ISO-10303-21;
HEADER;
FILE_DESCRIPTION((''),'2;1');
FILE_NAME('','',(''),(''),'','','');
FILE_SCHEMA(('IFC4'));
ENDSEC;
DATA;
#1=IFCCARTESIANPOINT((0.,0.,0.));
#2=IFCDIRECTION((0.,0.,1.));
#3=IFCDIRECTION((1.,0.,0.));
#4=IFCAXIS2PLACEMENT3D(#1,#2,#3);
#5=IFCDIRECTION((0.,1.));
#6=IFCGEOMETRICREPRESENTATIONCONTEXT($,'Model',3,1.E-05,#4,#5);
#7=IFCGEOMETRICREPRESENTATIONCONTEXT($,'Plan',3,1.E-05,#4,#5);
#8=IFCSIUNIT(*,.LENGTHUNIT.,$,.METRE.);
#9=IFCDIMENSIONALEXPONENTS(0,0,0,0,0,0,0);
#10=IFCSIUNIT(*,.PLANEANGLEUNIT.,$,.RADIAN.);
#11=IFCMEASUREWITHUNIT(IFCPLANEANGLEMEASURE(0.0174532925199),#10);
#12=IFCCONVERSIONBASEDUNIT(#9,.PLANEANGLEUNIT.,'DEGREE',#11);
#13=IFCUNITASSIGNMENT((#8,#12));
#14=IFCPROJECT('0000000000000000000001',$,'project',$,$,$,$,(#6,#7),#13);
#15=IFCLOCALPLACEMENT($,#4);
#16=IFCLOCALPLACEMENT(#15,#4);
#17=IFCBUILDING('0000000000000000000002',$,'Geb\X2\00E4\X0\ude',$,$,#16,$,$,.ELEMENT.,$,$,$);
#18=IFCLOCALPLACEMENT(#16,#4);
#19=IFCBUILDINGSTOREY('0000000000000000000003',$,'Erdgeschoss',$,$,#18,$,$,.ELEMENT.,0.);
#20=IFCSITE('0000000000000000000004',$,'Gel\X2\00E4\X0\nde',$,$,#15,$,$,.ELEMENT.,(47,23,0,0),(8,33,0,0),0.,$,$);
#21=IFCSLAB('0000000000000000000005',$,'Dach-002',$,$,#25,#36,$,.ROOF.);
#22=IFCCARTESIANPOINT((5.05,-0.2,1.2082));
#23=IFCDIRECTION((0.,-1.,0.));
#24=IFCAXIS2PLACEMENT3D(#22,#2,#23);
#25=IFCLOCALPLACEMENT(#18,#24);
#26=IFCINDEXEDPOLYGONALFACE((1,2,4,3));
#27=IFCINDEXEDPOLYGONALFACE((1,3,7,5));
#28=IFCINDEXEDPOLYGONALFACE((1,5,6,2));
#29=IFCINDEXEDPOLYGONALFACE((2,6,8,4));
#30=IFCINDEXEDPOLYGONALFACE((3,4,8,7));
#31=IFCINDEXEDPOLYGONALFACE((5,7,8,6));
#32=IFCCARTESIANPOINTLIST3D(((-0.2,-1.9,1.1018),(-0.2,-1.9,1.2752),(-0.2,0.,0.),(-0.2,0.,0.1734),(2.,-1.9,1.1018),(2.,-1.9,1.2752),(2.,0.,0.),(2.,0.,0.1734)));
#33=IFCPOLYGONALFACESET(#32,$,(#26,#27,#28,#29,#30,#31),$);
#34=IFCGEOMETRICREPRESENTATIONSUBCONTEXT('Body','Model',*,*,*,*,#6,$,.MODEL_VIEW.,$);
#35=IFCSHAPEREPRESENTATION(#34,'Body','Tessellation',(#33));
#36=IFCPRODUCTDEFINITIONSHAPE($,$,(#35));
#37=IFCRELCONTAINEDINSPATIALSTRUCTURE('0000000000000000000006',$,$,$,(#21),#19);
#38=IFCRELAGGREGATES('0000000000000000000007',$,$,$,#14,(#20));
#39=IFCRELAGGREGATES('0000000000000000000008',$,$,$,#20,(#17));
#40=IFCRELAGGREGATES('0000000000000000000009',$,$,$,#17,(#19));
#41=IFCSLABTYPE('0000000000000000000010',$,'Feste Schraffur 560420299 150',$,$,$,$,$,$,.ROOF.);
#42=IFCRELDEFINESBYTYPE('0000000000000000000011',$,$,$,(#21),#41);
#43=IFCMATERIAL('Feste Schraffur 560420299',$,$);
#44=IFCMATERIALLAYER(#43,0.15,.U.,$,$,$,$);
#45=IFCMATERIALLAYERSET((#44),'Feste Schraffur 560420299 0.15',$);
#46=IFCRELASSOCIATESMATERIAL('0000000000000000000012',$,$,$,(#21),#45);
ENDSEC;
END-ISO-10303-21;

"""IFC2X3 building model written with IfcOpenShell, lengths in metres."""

from ifc_helpers import new_model, entity, si_unit, converted_unit, direction, frame, origin_with_axes, place, context, subcontext, project, spatial, polyline, outline, extrude, material, layer, layer_set, layer_usage, type_object, element, save


model = new_model("IFC2X3")

# Units and contexts
model_context = context("Model", 3, precision=1e-05, world=origin_with_axes(), true_north=direction((0.0, 1.0)))
plan_context = context("Plan", 3, precision=1e-05, world=origin_with_axes(), true_north=direction((0.0, 1.0)))
body_context = subcontext(model_context, "Body", "Model", "MODEL_VIEW")
ifc_project = project(units=[si_unit("LENGTHUNIT", "METRE"), converted_unit("PLANEANGLEUNIT", "DEGREE", entity("IfcPlaneAngleMeasure", 0.0174532925199), si_unit("PLANEANGLEUNIT", "RADIAN"), dimensions=[0, 0, 0, 0, 0, 0, 0])], contexts=[model_context, plan_context])

# Site, building, storey
site_placement = place(None, origin_with_axes())
site = spatial("IfcSite", under=ifc_project, at=site_placement, Name="Gelände", CompositionType="ELEMENT", RefLatitude=(47, 23, 0, 0), RefLongitude=(8, 33, 0, 0), RefElevation=0.0)
building_placement = place(site_placement, origin_with_axes())
building = spatial("IfcBuilding", under=site, at=building_placement, Name="Gebäude", CompositionType="ELEMENT")
storey_placement = place(building_placement, origin_with_axes())
storey = spatial("IfcBuildingStorey", under=building, at=storey_placement, Name="Erdgeschoss", CompositionType="ELEMENT", Elevation=0.0)

# Slab
ifc_material_1 = material(Name="Feste Schraffur 560420299")
ifc_layer_1 = layer(ifc_material_1, 0.15, ventilated="UNKNOWN")
ifc_layer_set_1 = layer_set([ifc_layer_1], Name="Feste Schraffur 560420299 0.15")
ifc_layer_usage_1 = layer_usage(ifc_layer_set_1, "AXIS3", "NEGATIVE", 0.15)
slab_type_1 = type_object("IfcSlabType", Name="Feste Schraffur 560420299 150", PredefinedType="ROOF")
slab_1_placement = place(storey_placement, frame((5.05, -0.2, 1.2082), z_axis=(0.0, 0.0, 1.0), x_axis=(0.0, -1.0, 0.0)))
element("IfcSlab", 1, at=slab_1_placement, inside=storey, type_object=slab_type_1, material=ifc_layer_usage_1, Name="Dach-002", PredefinedType="ROOF", context=body_context, shape_type="SweptSolid", body=[
    extrude(outline(polyline([(-0.2, 0.0), (-0.2, -2.1964), (2.0, -2.1964), (2.0, 0.0), (-0.2, 0.0)])), frame((0.0, 0.0, 0.0), z_axis=(0.0, 0.501662, 0.865064), x_axis=(1.0, 0.0, 0.0)), (0.0, -0.501662, 0.865064), 0.1734),
])

save(model, "model.ifc")
